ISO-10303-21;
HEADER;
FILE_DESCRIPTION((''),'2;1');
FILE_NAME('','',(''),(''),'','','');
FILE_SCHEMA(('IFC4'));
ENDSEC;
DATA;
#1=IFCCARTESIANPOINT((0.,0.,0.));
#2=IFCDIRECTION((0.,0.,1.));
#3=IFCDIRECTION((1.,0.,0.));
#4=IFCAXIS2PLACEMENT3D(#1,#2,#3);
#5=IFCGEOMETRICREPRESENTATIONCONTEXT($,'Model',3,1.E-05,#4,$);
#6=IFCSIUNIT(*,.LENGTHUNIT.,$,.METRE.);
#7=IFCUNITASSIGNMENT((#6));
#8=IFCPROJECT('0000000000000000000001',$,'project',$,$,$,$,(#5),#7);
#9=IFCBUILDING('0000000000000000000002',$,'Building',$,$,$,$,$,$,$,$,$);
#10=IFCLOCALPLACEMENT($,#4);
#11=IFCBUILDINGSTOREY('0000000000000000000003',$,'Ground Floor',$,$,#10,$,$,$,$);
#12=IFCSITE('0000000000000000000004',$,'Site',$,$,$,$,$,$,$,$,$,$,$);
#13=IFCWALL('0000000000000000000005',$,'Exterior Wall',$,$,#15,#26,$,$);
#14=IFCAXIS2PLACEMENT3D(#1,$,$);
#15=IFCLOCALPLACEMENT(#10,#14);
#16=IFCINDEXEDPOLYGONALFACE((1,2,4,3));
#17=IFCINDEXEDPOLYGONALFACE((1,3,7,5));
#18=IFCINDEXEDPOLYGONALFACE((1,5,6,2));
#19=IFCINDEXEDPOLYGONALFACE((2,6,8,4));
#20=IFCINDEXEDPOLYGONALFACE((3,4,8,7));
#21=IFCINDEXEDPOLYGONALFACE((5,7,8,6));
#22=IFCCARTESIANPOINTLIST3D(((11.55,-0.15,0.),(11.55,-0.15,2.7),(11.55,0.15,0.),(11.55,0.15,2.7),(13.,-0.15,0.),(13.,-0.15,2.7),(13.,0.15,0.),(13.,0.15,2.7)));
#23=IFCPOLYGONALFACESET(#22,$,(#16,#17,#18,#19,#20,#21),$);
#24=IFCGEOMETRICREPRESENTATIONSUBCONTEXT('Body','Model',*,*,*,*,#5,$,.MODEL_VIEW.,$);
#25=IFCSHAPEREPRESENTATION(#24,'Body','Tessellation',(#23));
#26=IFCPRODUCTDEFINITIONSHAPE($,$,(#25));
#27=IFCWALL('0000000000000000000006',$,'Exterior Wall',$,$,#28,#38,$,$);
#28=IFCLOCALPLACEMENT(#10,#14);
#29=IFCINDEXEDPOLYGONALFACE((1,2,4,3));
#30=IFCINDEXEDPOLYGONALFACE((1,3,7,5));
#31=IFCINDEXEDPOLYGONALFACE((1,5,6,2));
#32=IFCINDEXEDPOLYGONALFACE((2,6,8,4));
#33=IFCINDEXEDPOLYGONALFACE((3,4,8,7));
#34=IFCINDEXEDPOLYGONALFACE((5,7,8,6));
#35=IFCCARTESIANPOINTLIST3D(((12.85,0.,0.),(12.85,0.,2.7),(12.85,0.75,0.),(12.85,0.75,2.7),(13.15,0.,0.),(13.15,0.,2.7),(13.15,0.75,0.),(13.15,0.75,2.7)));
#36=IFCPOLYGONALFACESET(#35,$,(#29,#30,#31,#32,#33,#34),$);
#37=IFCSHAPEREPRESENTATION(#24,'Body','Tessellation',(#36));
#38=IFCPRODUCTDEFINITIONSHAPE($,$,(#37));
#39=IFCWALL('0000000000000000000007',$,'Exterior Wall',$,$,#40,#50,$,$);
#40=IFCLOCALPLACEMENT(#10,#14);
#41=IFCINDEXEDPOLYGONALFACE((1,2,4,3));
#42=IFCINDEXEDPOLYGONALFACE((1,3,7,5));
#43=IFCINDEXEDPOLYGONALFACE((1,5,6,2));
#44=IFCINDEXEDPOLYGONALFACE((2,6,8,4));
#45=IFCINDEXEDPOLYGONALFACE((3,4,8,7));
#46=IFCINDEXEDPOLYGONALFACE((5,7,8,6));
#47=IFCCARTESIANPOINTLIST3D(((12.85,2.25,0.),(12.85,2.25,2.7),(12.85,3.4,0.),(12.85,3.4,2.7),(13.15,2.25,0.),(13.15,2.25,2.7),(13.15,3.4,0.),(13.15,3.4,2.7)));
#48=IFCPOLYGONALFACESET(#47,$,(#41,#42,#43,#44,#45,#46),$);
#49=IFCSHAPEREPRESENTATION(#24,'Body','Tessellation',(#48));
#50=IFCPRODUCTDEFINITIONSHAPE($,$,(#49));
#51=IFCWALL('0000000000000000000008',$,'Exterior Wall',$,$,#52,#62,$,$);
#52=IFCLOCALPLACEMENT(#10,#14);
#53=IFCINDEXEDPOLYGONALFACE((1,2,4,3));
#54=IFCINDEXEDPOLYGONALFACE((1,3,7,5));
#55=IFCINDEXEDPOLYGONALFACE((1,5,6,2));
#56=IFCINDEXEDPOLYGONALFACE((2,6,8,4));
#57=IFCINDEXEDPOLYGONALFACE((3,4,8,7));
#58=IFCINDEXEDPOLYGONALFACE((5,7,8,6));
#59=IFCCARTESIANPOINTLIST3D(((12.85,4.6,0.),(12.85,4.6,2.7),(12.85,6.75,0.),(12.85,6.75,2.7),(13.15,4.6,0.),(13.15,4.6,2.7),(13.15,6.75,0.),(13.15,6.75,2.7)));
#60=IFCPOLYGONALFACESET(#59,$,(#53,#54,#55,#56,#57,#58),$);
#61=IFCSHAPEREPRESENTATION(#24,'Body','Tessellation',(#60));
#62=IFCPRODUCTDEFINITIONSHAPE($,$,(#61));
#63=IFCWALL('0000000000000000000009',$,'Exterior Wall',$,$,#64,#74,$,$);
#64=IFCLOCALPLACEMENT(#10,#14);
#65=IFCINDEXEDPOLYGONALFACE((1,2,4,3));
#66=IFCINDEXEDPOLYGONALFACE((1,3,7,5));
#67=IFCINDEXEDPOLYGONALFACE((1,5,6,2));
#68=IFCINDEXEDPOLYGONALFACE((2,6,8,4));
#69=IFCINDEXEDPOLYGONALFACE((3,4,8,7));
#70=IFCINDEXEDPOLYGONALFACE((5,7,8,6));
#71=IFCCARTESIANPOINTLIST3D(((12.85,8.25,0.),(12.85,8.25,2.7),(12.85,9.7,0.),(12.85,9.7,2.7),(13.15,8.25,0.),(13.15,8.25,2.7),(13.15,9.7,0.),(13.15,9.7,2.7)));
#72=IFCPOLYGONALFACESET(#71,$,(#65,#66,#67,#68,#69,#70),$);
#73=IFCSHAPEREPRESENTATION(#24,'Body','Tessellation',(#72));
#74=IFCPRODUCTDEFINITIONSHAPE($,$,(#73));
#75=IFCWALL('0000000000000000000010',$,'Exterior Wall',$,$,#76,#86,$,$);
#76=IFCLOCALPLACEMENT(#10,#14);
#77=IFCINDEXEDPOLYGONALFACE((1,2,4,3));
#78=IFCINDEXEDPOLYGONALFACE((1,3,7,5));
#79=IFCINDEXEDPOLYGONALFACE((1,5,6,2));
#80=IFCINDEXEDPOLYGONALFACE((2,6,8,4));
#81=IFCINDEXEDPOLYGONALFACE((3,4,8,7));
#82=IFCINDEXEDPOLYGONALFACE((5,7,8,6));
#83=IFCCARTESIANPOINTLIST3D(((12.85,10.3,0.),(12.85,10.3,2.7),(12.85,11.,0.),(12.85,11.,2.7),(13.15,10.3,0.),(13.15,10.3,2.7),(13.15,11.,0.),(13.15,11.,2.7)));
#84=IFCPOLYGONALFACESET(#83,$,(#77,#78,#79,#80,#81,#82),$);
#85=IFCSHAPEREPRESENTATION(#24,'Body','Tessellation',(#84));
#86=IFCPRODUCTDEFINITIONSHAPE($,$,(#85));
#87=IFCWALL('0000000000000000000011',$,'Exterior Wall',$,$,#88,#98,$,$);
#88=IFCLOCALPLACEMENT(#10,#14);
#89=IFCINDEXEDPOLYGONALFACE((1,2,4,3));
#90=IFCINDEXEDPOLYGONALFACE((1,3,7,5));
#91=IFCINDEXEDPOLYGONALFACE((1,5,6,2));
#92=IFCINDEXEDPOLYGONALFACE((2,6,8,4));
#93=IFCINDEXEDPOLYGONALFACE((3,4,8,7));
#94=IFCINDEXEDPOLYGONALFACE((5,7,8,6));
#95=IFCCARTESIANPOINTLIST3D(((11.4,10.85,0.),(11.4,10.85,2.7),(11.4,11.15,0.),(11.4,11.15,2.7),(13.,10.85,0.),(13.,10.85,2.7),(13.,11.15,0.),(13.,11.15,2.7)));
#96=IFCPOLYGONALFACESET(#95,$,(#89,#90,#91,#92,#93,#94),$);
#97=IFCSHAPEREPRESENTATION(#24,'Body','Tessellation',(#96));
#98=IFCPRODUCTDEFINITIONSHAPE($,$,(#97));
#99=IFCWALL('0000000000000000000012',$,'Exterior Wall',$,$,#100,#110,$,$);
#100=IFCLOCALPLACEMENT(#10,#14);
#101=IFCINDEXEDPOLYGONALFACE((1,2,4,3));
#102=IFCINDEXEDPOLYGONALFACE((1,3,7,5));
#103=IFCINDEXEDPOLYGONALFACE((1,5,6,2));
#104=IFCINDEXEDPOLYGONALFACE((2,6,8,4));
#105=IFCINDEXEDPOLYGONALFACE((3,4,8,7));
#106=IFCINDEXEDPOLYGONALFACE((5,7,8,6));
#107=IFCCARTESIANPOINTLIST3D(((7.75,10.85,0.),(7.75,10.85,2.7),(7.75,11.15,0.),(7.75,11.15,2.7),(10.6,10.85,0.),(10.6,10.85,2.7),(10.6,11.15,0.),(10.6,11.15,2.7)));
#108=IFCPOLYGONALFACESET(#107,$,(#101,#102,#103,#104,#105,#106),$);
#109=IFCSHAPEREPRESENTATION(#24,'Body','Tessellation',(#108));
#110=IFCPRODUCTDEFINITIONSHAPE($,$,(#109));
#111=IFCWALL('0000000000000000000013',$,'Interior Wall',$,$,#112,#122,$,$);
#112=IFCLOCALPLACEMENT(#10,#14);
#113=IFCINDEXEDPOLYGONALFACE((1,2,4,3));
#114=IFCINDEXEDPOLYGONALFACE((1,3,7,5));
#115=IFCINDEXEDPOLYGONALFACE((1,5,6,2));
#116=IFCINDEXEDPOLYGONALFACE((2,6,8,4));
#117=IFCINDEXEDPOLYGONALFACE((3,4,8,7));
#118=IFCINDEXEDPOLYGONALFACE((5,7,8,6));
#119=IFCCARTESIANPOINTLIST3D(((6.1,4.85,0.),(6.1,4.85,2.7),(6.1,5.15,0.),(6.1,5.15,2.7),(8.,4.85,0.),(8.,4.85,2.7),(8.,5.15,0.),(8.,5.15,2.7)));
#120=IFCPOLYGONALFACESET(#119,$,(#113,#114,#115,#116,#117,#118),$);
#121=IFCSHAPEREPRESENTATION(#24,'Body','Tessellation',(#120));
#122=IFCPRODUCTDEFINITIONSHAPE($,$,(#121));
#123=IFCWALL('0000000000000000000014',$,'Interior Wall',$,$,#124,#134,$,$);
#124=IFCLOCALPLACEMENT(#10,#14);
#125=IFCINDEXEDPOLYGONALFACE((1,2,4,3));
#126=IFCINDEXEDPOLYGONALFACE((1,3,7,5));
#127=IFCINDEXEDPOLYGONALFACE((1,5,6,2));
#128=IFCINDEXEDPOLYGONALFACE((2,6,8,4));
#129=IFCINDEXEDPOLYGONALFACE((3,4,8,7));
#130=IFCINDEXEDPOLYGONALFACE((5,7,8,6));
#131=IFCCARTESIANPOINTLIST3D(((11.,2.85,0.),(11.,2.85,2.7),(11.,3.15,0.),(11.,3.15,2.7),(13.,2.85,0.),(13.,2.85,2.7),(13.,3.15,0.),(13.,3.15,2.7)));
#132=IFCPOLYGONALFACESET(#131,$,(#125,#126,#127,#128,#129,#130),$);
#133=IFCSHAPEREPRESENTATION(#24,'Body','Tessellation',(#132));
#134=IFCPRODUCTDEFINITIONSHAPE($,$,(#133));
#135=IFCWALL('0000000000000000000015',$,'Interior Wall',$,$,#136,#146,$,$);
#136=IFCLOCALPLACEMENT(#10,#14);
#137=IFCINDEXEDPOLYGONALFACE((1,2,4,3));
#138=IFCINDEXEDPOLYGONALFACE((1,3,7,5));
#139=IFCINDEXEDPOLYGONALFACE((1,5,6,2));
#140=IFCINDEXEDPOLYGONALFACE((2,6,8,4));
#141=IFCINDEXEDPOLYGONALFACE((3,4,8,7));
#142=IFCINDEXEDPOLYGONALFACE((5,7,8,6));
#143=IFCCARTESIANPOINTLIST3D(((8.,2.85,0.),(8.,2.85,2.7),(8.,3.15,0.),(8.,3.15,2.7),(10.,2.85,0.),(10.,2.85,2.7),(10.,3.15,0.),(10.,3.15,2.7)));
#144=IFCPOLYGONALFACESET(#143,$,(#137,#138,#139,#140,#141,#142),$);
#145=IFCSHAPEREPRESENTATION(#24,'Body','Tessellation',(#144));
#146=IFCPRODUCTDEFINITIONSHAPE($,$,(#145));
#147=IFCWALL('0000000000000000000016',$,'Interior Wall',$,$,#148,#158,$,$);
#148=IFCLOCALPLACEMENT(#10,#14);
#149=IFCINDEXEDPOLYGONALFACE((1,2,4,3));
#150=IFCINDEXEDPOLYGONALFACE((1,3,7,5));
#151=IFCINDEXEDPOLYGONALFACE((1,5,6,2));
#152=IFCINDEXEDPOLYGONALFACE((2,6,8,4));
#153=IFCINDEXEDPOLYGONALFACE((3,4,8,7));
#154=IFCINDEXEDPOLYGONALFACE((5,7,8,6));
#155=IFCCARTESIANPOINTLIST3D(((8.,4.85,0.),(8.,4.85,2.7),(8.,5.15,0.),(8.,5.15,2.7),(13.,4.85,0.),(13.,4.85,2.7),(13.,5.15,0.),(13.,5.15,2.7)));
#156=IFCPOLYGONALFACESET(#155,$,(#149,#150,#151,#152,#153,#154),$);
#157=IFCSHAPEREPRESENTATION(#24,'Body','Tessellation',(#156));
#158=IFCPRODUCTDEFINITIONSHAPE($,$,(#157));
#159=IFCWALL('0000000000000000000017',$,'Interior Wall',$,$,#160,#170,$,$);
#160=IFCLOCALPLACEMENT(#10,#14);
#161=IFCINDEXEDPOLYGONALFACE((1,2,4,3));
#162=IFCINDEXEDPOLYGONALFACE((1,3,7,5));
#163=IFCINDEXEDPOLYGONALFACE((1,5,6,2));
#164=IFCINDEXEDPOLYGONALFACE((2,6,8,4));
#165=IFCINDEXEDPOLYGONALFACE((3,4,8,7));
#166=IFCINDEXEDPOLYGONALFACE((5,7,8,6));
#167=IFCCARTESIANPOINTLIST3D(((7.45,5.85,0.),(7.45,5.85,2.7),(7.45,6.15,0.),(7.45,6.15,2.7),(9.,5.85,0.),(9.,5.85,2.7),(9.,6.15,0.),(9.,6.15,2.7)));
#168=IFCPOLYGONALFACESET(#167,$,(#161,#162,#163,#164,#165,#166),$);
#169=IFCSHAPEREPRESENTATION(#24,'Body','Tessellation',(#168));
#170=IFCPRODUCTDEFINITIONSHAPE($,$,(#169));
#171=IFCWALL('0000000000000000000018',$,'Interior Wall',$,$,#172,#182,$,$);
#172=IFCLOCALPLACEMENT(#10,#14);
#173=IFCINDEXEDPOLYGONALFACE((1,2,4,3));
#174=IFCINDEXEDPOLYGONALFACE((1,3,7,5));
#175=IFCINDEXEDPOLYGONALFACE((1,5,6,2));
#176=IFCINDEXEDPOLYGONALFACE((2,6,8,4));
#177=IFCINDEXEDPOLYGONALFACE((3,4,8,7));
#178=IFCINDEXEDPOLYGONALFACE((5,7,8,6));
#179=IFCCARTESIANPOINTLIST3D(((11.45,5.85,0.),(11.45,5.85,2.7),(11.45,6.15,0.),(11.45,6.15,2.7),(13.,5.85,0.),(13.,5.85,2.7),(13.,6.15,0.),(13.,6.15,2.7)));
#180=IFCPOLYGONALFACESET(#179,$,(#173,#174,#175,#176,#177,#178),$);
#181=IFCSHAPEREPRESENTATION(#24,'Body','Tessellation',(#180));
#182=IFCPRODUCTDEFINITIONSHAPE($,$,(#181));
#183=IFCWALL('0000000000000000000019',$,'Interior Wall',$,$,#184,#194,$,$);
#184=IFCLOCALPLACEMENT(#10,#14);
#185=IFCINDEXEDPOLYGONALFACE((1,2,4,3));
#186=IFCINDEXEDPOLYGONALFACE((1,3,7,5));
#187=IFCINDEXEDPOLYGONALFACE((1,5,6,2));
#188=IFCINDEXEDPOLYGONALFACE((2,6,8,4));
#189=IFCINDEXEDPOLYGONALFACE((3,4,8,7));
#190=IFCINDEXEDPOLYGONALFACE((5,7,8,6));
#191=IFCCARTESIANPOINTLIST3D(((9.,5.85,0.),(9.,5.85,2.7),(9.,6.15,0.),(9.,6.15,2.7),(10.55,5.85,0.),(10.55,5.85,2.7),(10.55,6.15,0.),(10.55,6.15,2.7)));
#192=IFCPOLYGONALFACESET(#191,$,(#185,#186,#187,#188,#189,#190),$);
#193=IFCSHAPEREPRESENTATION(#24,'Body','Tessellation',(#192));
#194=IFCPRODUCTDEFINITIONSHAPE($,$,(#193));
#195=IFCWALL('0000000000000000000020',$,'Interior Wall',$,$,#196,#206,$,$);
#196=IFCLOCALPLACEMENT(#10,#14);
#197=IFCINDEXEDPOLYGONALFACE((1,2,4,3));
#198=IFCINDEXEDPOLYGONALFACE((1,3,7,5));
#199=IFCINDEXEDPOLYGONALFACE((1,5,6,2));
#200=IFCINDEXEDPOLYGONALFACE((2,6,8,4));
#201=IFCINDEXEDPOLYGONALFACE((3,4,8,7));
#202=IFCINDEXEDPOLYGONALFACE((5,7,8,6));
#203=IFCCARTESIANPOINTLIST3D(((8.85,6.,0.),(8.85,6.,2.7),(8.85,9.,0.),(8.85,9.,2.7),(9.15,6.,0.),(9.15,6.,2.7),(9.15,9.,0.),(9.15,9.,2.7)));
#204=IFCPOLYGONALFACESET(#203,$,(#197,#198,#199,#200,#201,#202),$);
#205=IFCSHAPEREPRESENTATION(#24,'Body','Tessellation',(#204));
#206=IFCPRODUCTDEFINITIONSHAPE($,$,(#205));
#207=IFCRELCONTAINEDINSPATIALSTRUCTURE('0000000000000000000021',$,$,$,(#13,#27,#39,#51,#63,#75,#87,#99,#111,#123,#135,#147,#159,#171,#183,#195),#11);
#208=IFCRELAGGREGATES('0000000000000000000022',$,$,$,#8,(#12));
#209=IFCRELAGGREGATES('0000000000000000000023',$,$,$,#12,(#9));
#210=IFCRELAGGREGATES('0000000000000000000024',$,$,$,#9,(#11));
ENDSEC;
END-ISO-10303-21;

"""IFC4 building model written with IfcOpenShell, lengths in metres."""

from ifc_helpers import new_model, si_unit, frame, origin_with_axes, place, context, subcontext, project, spatial, indexed_curve, outline, extrude, element, save


model = new_model("IFC4")

# Units and contexts
model_context = context("Model", 3, precision=1e-05, world=origin_with_axes())
body_context = subcontext(model_context, "Body", "Model", "MODEL_VIEW")
ifc_project = project(units=[si_unit("LENGTHUNIT", "METRE")], contexts=[model_context])

# Site, building, storey
site = spatial("IfcSite", under=ifc_project, Name="Site")
building = spatial("IfcBuilding", under=site, Name="Building")
storey_placement = place(None, origin_with_axes())
storey = spatial("IfcBuildingStorey", under=building, at=storey_placement, Name="Ground Floor")

# Walls
wall_1_placement = place(storey_placement, frame((11.55, 0.0, 0.0), z_axis=(0.0, 0.0, 1.0), x_axis=(1.0, 0.0, 0.0)))
element("IfcWall", 1, at=wall_1_placement, inside=storey, Name="Exterior Wall", context=body_context, shape_type="SweptSolid", body=[
    extrude(outline(indexed_curve([(0.0, 0.0), (0.0, 0.3), (1.45, 0.3), (1.45, 0.0), (0.0, 0.0)], self_intersect=False)), frame((0.0, -0.15, 0.0), z_axis=(0.0, 0.0, 1.0), x_axis=(1.0, 0.0, 0.0)), (0.0, 0.0, 1.0), 2.7),
])
wall_2_placement = place(storey_placement, frame((13.0, 0.0, 0.0), z_axis=(0.0, 0.0, 1.0), x_axis=(0.0, 1.0, 0.0)))
element("IfcWall", 2, at=wall_2_placement, inside=storey, Name="Exterior Wall", context=body_context, shape_type="SweptSolid", body=[
    extrude(outline(indexed_curve([(0.0, 0.0), (0.0, 0.3), (0.75, 0.3), (0.75, 0.0), (0.0, 0.0)], self_intersect=False)), frame((0.0, -0.15, 0.0), z_axis=(0.0, 0.0, 1.0), x_axis=(1.0, 0.0, 0.0)), (0.0, 0.0, 1.0), 2.7),
])
wall_3_placement = place(storey_placement, frame((13.0, 2.25, 0.0), z_axis=(0.0, 0.0, 1.0), x_axis=(0.0, 1.0, 0.0)))
element("IfcWall", 3, at=wall_3_placement, inside=storey, Name="Exterior Wall", context=body_context, shape_type="SweptSolid", body=[
    extrude(outline(indexed_curve([(0.0, 0.0), (0.0, 0.3), (1.15, 0.3), (1.15, 0.0), (0.0, 0.0)], self_intersect=False)), frame((0.0, -0.15, 0.0), z_axis=(0.0, 0.0, 1.0), x_axis=(1.0, 0.0, 0.0)), (0.0, 0.0, 1.0), 2.7),
])
wall_4_placement = place(storey_placement, frame((13.0, 4.6, 0.0), z_axis=(0.0, 0.0, 1.0), x_axis=(0.0, 1.0, 0.0)))
element("IfcWall", 4, at=wall_4_placement, inside=storey, Name="Exterior Wall", context=body_context, shape_type="SweptSolid", body=[
    extrude(outline(indexed_curve([(0.0, 0.0), (0.0, 0.3), (2.15, 0.3), (2.15, 0.0), (0.0, 0.0)], self_intersect=False)), frame((0.0, -0.15, 0.0), z_axis=(0.0, 0.0, 1.0), x_axis=(1.0, 0.0, 0.0)), (0.0, 0.0, 1.0), 2.7),
])
wall_5_placement = place(storey_placement, frame((13.0, 8.25, 0.0), z_axis=(0.0, 0.0, 1.0), x_axis=(0.0, 1.0, 0.0)))
element("IfcWall", 5, at=wall_5_placement, inside=storey, Name="Exterior Wall", context=body_context, shape_type="SweptSolid", body=[
    extrude(outline(indexed_curve([(0.0, 0.0), (0.0, 0.3), (1.45, 0.3), (1.45, 0.0), (0.0, 0.0)], self_intersect=False)), frame((0.0, -0.15, 0.0), z_axis=(0.0, 0.0, 1.0), x_axis=(1.0, 0.0, 0.0)), (0.0, 0.0, 1.0), 2.7),
])
wall_6_placement = place(storey_placement, frame((13.0, 10.3, 0.0), z_axis=(0.0, 0.0, 1.0), x_axis=(0.0, 1.0, 0.0)))
element("IfcWall", 6, at=wall_6_placement, inside=storey, Name="Exterior Wall", context=body_context, shape_type="SweptSolid", body=[
    extrude(outline(indexed_curve([(0.0, 0.0), (0.0, 0.3), (0.7, 0.3), (0.7, 0.0), (0.0, 0.0)], self_intersect=False)), frame((0.0, -0.15, 0.0), z_axis=(0.0, 0.0, 1.0), x_axis=(1.0, 0.0, 0.0)), (0.0, 0.0, 1.0), 2.7),
])
wall_7_placement = place(storey_placement, frame((13.0, 11.0, 0.0), z_axis=(0.0, 0.0, 1.0), x_axis=(-1.0, 0.0, 0.0)))
element("IfcWall", 7, at=wall_7_placement, inside=storey, Name="Exterior Wall", context=body_context, shape_type="SweptSolid", body=[
    extrude(outline(indexed_curve([(0.0, 0.0), (0.0, 0.3), (1.6, 0.3), (1.6, 0.0), (0.0, 0.0)], self_intersect=False)), frame((0.0, -0.15, 0.0), z_axis=(0.0, 0.0, 1.0), x_axis=(1.0, 0.0, 0.0)), (0.0, 0.0, 1.0), 2.7),
])
wall_8_placement = place(storey_placement, frame((10.6, 11.0, 0.0), z_axis=(0.0, 0.0, 1.0), x_axis=(-1.0, 0.0, 0.0)))
element("IfcWall", 8, at=wall_8_placement, inside=storey, Name="Exterior Wall", context=body_context, shape_type="SweptSolid", body=[
    extrude(outline(indexed_curve([(0.0, 0.0), (0.0, 0.3), (2.85, 0.3), (2.85, 0.0), (0.0, 0.0)], self_intersect=False)), frame((0.0, -0.15, 0.0), z_axis=(0.0, 0.0, 1.0), x_axis=(1.0, 0.0, 0.0)), (0.0, 0.0, 1.0), 2.7),
])
wall_9_placement = place(storey_placement, frame((8.0, 5.0, 0.0), z_axis=(0.0, 0.0, 1.0), x_axis=(-1.0, 0.0, 0.0)))
element("IfcWall", 9, at=wall_9_placement, inside=storey, Name="Interior Wall", context=body_context, shape_type="SweptSolid", body=[
    extrude(outline(indexed_curve([(0.0, 0.0), (0.0, 0.3), (1.9, 0.3), (1.9, 0.0), (0.0, 0.0)], self_intersect=False)), frame((0.0, -0.15, 0.0), z_axis=(0.0, 0.0, 1.0), x_axis=(1.0, 0.0, 0.0)), (0.0, 0.0, 1.0), 2.7),
])
for number, where, z_axis, x_axis, name in (
    (10, (13.0, 3.0, 0.0), (0.0, 0.0, 1.0), (-1.0, 0.0, 0.0), "Interior Wall"),
    (11, (10.0, 3.0, 0.0), (0.0, 0.0, 1.0), (-1.0, 0.0, 0.0), "Interior Wall"),
):
    element("IfcWall", number, at=place(storey_placement, frame(where, z_axis=z_axis, x_axis=x_axis)), inside=storey, Name=name, context=body_context, shape_type="SweptSolid", body=[
        extrude(outline(indexed_curve([(0.0, 0.0), (0.0, 0.3), (2.0, 0.3), (2.0, 0.0), (0.0, 0.0)], self_intersect=False)), frame((0.0, -0.15, 0.0), z_axis=(0.0, 0.0, 1.0), x_axis=(1.0, 0.0, 0.0)), (0.0, 0.0, 1.0), 2.7),
    ])
wall_10_placement = place(storey_placement, frame((13.0, 5.0, 0.0), z_axis=(0.0, 0.0, 1.0), x_axis=(-1.0, 0.0, 0.0)))
element("IfcWall", 12, at=wall_10_placement, inside=storey, Name="Interior Wall", context=body_context, shape_type="SweptSolid", body=[
    extrude(outline(indexed_curve([(0.0, 0.0), (0.0, 0.3), (5.0, 0.3), (5.0, 0.0), (0.0, 0.0)], self_intersect=False)), frame((0.0, -0.15, 0.0), z_axis=(0.0, 0.0, 1.0), x_axis=(1.0, 0.0, 0.0)), (0.0, 0.0, 1.0), 2.7),
])
wall_11_placement = place(storey_placement, frame((9.0, 6.0, 0.0), z_axis=(0.0, 0.0, 1.0), x_axis=(-1.0, 0.0, 0.0)))
element("IfcWall", 13, at=wall_11_placement, inside=storey, Name="Interior Wall", context=body_context, shape_type="SweptSolid", body=[
    extrude(outline(indexed_curve([(0.0, 0.0), (0.0, 0.3), (1.55, 0.3), (1.55, 0.0), (0.0, 0.0)], self_intersect=False)), frame((0.0, -0.15, 0.0), z_axis=(0.0, 0.0, 1.0), x_axis=(1.0, 0.0, 0.0)), (0.0, 0.0, 1.0), 2.7),
])
for number, where, z_axis, x_axis, name in (
    (14, (13.0, 6.0, 0.0), (0.0, 0.0, 1.0), (-1.0, 0.0, 0.0), "Interior Wall"),
    (15, (10.55, 6.0, 0.0), (0.0, 0.0, 1.0), (-1.0, 0.0, 0.0), "Interior Wall"),
):
    element("IfcWall", number, at=place(storey_placement, frame(where, z_axis=z_axis, x_axis=x_axis)), inside=storey, Name=name, context=body_context, shape_type="SweptSolid", body=[
        extrude(outline(indexed_curve([(0.0, 0.0), (0.0, 0.3), (1.55, 0.3), (1.55, 0.0), (0.0, 0.0)], self_intersect=False)), frame((0.0, -0.15, 0.0), z_axis=(0.0, 0.0, 1.0), x_axis=(1.0, 0.0, 0.0)), (0.0, 0.0, 1.0), 2.7),
    ])
wall_12_placement = place(storey_placement, frame((9.0, 6.0, 0.0), z_axis=(0.0, 0.0, 1.0), x_axis=(0.0, 1.0, 0.0)))
element("IfcWall", 16, at=wall_12_placement, inside=storey, Name="Interior Wall", context=body_context, shape_type="SweptSolid", body=[
    extrude(outline(indexed_curve([(0.0, 0.0), (0.0, 0.3), (3.0, 0.3), (3.0, 0.0), (0.0, 0.0)], self_intersect=False)), frame((0.0, -0.15, 0.0), z_axis=(0.0, 0.0, 1.0), x_axis=(1.0, 0.0, 0.0)), (0.0, 0.0, 1.0), 2.7),
])

save(model, "model.ifc")
